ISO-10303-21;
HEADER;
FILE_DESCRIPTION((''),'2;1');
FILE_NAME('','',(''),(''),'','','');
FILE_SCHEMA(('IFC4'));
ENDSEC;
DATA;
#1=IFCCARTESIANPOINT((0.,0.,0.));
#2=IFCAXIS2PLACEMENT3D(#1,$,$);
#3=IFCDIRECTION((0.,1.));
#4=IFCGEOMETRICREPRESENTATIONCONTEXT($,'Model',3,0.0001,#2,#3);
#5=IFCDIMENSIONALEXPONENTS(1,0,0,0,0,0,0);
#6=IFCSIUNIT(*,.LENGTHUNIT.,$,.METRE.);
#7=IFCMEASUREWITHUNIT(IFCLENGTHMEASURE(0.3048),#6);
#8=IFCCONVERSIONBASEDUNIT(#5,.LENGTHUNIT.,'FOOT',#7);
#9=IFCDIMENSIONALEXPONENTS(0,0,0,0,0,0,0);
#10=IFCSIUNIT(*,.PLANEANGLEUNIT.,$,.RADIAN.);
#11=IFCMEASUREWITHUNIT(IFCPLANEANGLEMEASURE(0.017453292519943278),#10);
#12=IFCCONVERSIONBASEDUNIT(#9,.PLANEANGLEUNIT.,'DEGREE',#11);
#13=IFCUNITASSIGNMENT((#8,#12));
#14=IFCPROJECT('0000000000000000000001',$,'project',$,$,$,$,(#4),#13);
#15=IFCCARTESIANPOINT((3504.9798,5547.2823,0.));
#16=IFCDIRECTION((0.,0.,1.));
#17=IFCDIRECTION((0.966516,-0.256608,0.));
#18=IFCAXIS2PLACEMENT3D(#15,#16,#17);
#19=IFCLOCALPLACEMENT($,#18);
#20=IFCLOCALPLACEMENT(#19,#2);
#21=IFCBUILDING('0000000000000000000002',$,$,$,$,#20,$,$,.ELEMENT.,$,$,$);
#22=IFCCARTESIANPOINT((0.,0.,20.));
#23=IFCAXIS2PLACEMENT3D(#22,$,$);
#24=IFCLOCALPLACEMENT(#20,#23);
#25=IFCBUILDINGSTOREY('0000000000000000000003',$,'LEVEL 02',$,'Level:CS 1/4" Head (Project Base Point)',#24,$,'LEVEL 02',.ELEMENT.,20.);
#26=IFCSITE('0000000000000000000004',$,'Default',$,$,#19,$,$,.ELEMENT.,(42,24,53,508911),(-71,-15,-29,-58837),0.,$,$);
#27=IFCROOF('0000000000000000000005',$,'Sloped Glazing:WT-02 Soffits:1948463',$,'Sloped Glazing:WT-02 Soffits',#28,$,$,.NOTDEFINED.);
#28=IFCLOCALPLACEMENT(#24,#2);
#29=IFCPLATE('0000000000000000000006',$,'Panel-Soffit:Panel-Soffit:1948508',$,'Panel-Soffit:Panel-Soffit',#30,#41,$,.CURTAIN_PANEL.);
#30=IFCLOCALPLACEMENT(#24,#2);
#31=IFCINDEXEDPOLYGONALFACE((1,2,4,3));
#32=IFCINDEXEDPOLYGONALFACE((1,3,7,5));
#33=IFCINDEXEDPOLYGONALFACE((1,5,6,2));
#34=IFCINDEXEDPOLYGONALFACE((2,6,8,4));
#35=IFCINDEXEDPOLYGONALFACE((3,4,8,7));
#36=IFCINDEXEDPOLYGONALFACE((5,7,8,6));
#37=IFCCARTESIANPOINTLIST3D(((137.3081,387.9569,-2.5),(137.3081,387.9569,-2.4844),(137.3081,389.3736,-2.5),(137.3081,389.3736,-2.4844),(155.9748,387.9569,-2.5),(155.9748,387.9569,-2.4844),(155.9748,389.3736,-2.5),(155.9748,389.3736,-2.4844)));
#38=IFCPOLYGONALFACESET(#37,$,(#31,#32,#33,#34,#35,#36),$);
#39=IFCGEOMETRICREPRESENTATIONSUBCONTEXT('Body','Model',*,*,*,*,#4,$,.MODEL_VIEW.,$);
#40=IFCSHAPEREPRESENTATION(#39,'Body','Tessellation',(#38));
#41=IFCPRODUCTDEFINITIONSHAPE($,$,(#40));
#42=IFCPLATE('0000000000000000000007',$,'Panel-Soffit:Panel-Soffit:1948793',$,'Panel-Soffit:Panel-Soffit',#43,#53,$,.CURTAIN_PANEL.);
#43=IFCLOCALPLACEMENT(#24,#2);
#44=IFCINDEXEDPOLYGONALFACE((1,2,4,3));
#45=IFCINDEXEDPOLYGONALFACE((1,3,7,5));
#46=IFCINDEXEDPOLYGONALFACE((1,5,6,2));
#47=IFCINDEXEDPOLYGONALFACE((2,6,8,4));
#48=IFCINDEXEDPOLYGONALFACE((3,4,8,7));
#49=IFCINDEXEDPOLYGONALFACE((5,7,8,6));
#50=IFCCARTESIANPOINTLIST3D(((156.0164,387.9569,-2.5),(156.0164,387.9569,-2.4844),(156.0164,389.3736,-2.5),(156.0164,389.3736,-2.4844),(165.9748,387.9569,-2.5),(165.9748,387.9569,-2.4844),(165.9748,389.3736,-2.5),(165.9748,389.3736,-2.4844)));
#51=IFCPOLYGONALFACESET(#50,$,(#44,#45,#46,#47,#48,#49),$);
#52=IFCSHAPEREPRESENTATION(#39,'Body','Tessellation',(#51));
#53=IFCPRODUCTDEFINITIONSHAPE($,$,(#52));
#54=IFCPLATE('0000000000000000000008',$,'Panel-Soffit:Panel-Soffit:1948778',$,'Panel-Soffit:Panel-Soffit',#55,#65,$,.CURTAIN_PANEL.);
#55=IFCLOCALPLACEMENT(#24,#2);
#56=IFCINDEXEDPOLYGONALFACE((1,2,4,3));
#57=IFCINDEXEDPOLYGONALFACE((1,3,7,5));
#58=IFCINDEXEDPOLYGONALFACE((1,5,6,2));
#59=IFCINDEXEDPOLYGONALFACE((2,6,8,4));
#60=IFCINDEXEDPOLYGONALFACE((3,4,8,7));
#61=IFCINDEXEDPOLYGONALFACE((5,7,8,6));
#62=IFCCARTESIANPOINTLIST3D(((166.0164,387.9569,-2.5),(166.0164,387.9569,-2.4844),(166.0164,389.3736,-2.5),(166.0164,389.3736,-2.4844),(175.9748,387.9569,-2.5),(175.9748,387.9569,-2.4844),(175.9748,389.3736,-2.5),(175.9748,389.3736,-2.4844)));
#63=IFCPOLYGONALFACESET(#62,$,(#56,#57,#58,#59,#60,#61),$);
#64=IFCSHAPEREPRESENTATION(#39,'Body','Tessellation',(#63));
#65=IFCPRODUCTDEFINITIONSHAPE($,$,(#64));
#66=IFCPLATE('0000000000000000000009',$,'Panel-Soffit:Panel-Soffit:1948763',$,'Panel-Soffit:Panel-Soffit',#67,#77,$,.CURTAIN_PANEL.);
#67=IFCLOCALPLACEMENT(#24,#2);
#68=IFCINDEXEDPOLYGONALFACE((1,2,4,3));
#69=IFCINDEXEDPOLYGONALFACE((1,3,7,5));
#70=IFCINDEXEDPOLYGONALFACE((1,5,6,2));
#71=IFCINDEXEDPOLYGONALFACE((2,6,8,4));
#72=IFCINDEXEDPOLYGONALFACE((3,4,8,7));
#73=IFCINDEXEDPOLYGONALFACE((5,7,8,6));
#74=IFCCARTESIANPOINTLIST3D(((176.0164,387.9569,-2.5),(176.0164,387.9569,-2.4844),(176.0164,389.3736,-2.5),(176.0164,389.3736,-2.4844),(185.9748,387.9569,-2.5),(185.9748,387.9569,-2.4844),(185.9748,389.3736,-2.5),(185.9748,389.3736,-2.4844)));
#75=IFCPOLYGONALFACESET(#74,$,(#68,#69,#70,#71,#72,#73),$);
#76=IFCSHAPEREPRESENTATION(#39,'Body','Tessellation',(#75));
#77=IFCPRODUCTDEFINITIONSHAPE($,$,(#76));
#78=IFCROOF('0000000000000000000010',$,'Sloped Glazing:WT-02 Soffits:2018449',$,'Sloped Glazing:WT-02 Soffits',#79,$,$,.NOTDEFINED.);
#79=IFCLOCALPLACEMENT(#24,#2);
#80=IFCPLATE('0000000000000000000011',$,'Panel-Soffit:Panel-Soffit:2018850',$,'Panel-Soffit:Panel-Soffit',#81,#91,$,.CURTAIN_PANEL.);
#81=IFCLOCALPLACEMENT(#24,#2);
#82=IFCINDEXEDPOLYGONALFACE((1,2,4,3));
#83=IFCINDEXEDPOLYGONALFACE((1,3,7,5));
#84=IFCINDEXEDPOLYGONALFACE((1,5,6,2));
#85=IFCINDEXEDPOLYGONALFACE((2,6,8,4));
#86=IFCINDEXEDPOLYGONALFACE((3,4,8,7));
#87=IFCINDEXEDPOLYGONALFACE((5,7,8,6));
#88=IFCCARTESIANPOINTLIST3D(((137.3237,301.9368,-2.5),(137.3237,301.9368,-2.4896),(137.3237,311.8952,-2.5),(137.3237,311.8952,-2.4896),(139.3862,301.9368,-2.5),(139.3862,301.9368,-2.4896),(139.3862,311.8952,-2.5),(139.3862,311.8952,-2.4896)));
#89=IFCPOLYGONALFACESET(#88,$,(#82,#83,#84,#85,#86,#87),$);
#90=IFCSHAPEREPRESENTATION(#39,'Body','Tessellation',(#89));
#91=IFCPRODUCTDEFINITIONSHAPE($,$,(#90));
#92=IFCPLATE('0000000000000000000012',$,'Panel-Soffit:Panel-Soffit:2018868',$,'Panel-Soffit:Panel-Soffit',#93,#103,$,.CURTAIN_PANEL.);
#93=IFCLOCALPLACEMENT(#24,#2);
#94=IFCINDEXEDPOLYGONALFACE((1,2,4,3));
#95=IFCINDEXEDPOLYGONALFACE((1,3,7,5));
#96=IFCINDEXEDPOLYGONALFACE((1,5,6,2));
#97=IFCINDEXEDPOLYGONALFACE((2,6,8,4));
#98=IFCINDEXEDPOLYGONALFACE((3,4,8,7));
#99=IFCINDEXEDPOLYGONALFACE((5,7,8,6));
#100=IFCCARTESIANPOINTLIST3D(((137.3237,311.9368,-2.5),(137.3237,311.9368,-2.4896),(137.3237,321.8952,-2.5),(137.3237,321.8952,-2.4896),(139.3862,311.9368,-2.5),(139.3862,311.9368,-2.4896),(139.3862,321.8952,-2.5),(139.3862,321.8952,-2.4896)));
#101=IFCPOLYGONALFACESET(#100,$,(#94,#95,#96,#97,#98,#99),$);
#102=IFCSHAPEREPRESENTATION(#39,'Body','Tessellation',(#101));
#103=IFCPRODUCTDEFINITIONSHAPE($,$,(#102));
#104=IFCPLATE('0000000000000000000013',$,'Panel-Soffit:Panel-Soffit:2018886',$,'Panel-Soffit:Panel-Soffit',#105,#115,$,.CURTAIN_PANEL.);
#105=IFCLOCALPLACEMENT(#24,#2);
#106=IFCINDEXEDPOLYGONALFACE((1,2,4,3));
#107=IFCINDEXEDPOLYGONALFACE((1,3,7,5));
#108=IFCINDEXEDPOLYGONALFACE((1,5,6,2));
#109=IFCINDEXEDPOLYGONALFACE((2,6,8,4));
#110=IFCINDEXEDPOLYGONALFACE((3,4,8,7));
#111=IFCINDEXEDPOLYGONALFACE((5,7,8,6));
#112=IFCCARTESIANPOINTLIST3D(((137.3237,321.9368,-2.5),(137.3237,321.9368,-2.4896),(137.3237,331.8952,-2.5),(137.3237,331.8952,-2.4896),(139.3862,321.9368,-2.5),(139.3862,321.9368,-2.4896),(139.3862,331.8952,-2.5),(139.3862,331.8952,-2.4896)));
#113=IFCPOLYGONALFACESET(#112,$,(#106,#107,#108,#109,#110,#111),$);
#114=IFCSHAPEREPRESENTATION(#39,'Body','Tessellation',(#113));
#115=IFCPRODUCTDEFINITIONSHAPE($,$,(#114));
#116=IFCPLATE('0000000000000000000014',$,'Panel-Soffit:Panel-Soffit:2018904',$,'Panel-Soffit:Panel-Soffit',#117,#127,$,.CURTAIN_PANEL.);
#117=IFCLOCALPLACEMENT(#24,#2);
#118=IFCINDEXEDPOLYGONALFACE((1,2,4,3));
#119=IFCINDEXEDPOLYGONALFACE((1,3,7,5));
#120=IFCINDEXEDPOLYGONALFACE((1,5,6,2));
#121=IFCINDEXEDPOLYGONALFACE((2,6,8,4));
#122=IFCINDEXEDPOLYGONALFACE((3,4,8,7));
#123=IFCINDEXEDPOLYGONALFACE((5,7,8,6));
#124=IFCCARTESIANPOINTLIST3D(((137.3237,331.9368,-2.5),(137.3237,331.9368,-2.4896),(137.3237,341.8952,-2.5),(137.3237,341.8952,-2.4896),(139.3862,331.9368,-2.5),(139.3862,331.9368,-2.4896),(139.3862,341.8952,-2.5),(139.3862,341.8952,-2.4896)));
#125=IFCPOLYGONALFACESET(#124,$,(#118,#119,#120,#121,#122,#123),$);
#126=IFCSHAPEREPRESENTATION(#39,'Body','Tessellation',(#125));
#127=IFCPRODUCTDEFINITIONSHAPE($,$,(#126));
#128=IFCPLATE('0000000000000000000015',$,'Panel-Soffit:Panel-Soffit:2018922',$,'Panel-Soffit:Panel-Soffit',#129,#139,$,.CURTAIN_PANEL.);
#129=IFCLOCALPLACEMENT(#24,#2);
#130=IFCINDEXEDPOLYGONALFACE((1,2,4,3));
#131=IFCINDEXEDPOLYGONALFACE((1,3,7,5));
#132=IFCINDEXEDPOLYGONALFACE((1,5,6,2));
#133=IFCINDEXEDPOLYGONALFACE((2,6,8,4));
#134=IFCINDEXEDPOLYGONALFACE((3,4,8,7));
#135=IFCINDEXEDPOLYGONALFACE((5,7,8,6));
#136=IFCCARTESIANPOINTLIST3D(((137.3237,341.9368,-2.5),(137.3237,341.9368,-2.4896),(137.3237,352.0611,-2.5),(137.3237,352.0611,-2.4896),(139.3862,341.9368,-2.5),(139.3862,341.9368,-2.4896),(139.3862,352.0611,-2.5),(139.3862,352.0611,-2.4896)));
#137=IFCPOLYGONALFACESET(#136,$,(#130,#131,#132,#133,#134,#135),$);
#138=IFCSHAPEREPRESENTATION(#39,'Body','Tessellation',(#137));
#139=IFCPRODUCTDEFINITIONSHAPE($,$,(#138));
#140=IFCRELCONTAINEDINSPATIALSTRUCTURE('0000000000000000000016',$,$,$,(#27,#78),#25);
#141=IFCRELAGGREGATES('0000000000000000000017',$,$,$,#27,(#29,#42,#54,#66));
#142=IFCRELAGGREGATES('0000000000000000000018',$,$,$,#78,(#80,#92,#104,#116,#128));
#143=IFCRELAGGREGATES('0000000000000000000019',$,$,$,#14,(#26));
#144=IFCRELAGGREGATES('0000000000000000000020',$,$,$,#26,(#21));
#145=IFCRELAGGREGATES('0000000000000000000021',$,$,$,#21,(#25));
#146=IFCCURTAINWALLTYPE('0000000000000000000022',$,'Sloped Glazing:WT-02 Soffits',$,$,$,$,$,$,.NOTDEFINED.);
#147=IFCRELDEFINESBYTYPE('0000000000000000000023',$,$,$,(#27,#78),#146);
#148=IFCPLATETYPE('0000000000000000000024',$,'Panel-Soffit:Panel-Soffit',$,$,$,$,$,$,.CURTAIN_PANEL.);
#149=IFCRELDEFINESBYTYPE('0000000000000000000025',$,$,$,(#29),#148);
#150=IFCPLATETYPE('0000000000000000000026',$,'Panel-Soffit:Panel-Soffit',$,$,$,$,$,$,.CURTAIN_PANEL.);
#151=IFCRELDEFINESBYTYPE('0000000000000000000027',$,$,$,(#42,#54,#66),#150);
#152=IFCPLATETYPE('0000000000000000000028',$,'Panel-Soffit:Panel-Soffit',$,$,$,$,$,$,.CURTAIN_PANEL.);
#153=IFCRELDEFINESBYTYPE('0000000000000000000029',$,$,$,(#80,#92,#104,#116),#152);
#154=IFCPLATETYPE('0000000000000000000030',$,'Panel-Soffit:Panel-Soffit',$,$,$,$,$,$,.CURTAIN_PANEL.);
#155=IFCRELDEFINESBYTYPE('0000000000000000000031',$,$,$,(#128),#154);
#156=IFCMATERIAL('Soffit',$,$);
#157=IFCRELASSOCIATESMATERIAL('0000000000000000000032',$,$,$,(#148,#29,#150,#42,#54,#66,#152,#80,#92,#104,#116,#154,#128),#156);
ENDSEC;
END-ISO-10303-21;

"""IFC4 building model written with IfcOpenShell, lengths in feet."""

from ifc_helpers import new_model, entity, si_unit, converted_unit, direction, frame, origin, place, context, subcontext, project, spatial, indexed_curve, outline, extrude, source, transform, mapped, material, type_object, type_shapes, element, aggregate, save


model = new_model("IFC4")

# Units and contexts
model_context = context("Model", 3, precision=0.0001, world=origin(), true_north=direction((0.0, 1.0)))
body_context = subcontext(model_context, "Body", "Model", "MODEL_VIEW")
ifc_project = project(units=[converted_unit("LENGTHUNIT", "FOOT", entity("IfcLengthMeasure", 0.3048), si_unit("LENGTHUNIT", "METRE"), dimensions=[1, 0, 0, 0, 0, 0, 0]), converted_unit("PLANEANGLEUNIT", "DEGREE", entity("IfcPlaneAngleMeasure", 0.017453292519943278), si_unit("PLANEANGLEUNIT", "RADIAN"), dimensions=[0, 0, 0, 0, 0, 0, 0])], contexts=[model_context])

# Site, building, storey
site_placement = place(None, frame((3504.9798, 5547.2823, 0.0), z_axis=(0.0, 0.0, 1.0), x_axis=(0.966516, -0.256608, 0.0)))
site = spatial("IfcSite", under=ifc_project, at=site_placement, Name="Default", CompositionType="ELEMENT", RefLatitude=(42, 24, 53, 508911), RefLongitude=(-71, -15, -29, -58837), RefElevation=0.0)
building_placement = place(site_placement, origin())
building = spatial("IfcBuilding", under=site, at=building_placement, CompositionType="ELEMENT")
storey_placement = place(building_placement, frame((0.0, 0.0, 20.0)))
storey = spatial("IfcBuildingStorey", under=building, at=storey_placement, Name="LEVEL 02", ObjectType="Level:CS 1/4\" Head (Project Base Point)", LongName="LEVEL 02", CompositionType="ELEMENT", Elevation=20.0)

# Roofs, plates
curtain_wall_type_1 = type_object("IfcCurtainWallType", Name="Sloped Glazing:WT-02 Soffits", PredefinedType="NOTDEFINED")
ifc_material_1 = material(Name="Soffit")
roof_1_placement = place(storey_placement, frame((0.0, 0.0, -20.0)))
roof_1 = element("IfcRoof", 1, at=roof_1_placement, inside=storey, type_object=curtain_wall_type_1, Name="Sloped Glazing:WT-02 Soffits:1948463", ObjectType="Sloped Glazing:WT-02 Soffits", PredefinedType="NOTDEFINED")
plate_type_1 = type_object("IfcPlateType", Name="Panel-Soffit:Panel-Soffit", PredefinedType="CURTAIN_PANEL", material=ifc_material_1)
shared_shape_1 = source(origin(), body_context, "Body", "SweptSolid", [
    extrude(outline(indexed_curve([(-0.0078, -9.3333), (0.0078, -9.3333), (0.0078, 9.3333), (-0.0078, 9.3333), (-0.0078, -9.3333)], self_intersect=False)), frame((9.3333, 0.0078, 0.0), z_axis=(0.0, 0.0, 1.0), x_axis=(0.0, -1.0, 0.0)), (0.0, 0.0, 1.0), 1.4167),
])
type_shapes(plate_type_1, [shared_shape_1])
plate_1_placement = place(roof_1_placement, frame((137.3081, 387.9569, 17.5156), z_axis=(0.0, 1.0, 0.0), x_axis=(1.0, 0.0, 0.0)))
plate_1 = element("IfcPlate", 2, at=plate_1_placement, type_object=plate_type_1, material=ifc_material_1, Name="Panel-Soffit:Panel-Soffit:1948508", ObjectType="Panel-Soffit:Panel-Soffit", PredefinedType="CURTAIN_PANEL", context=body_context, shape_type="MappedRepresentation", body=[
    mapped(shared_shape_1, transform((0.0, 0.0, 0.0), scale=1.0)),
])
plate_type_2 = type_object("IfcPlateType", Name="Panel-Soffit:Panel-Soffit", PredefinedType="CURTAIN_PANEL", material=ifc_material_1)
shared_shape_2 = source(origin(), body_context, "Body", "SweptSolid", [
    extrude(outline(indexed_curve([(-0.0078, -4.9792), (0.0078, -4.9792), (0.0078, 4.9792), (-0.0078, 4.9792), (-0.0078, -4.9792)], self_intersect=False)), frame((4.9792, 0.0078, 0.0), z_axis=(0.0, 0.0, 1.0), x_axis=(0.0, -1.0, 0.0)), (0.0, 0.0, 1.0), 1.4167),
])
type_shapes(plate_type_2, [shared_shape_2])
plate_2_placement = place(roof_1_placement, frame((156.0164, 387.9569, 17.5156), z_axis=(0.0, 1.0, 0.0), x_axis=(1.0, 0.0, 0.0)))
plate_2 = element("IfcPlate", 3, at=plate_2_placement, type_object=plate_type_2, material=ifc_material_1, Name="Panel-Soffit:Panel-Soffit:1948793", ObjectType="Panel-Soffit:Panel-Soffit", PredefinedType="CURTAIN_PANEL", context=body_context, shape_type="MappedRepresentation", body=[
    mapped(shared_shape_2, transform((0.0, 0.0, 0.0), scale=1.0)),
])
plate_3_placement = place(roof_1_placement, frame((166.0164, 387.9569, 17.5156), z_axis=(0.0, 1.0, 0.0), x_axis=(1.0, 0.0, 0.0)))
plate_3 = element("IfcPlate", 4, at=plate_3_placement, type_object=plate_type_2, material=ifc_material_1, Name="Panel-Soffit:Panel-Soffit:1948778", ObjectType="Panel-Soffit:Panel-Soffit", PredefinedType="CURTAIN_PANEL", context=body_context, shape_type="MappedRepresentation", body=[
    mapped(shared_shape_2, transform((0.0, 0.0, 0.0), scale=1.0)),
])
plate_4_placement = place(roof_1_placement, frame((176.0164, 387.9569, 17.5156), z_axis=(0.0, 1.0, 0.0), x_axis=(1.0, 0.0, 0.0)))
plate_4 = element("IfcPlate", 5, at=plate_4_placement, type_object=plate_type_2, material=ifc_material_1, Name="Panel-Soffit:Panel-Soffit:1948763", ObjectType="Panel-Soffit:Panel-Soffit", PredefinedType="CURTAIN_PANEL", context=body_context, shape_type="MappedRepresentation", body=[
    mapped(shared_shape_2, transform((0.0, 0.0, 0.0), scale=1.0)),
])
aggregate(roof_1, [plate_1, plate_2, plate_3, plate_4])
roof_2_placement = place(storey_placement, frame((0.0, 0.0, -20.0)))
roof_2 = element("IfcRoof", 6, at=roof_2_placement, inside=storey, type_object=curtain_wall_type_1, Name="Sloped Glazing:WT-02 Soffits:2018449", ObjectType="Sloped Glazing:WT-02 Soffits", PredefinedType="NOTDEFINED")
plate_type_3 = type_object("IfcPlateType", Name="Panel-Soffit:Panel-Soffit", PredefinedType="CURTAIN_PANEL", material=ifc_material_1)
shared_shape_3 = source(origin(), body_context, "Body", "SweptSolid", [
    extrude(outline(indexed_curve([(-0.0052, -1.0313), (0.0052, -1.0313), (0.0052, 1.0313), (-0.0052, 1.0313), (-0.0052, -1.0313)], self_intersect=False)), frame((1.0313, 0.0052, 0.0), z_axis=(0.0, 0.0, 1.0), x_axis=(0.0, -1.0, 0.0)), (0.0, 0.0, 1.0), 9.9583),
])
type_shapes(plate_type_3, [shared_shape_3])
plate_5_placement = place(roof_2_placement, frame((137.3237, 301.9368, 17.5104), z_axis=(0.0, 1.0, 0.0), x_axis=(1.0, 0.0, 0.0)))
plate_5 = element("IfcPlate", 7, at=plate_5_placement, type_object=plate_type_3, material=ifc_material_1, Name="Panel-Soffit:Panel-Soffit:2018850", ObjectType="Panel-Soffit:Panel-Soffit", PredefinedType="CURTAIN_PANEL", context=body_context, shape_type="MappedRepresentation", body=[
    mapped(shared_shape_3, transform((0.0, 0.0, 0.0), scale=1.0)),
])
plate_6_placement = place(roof_2_placement, frame((137.3237, 311.9368, 17.5104), z_axis=(0.0, 1.0, 0.0), x_axis=(1.0, 0.0, 0.0)))
plate_6 = element("IfcPlate", 8, at=plate_6_placement, type_object=plate_type_3, material=ifc_material_1, Name="Panel-Soffit:Panel-Soffit:2018868", ObjectType="Panel-Soffit:Panel-Soffit", PredefinedType="CURTAIN_PANEL", context=body_context, shape_type="MappedRepresentation", body=[
    mapped(shared_shape_3, transform((0.0, 0.0, 0.0), scale=1.0)),
])
plate_7_placement = place(roof_2_placement, frame((137.3237, 321.9368, 17.5104), z_axis=(0.0, 1.0, 0.0), x_axis=(1.0, 0.0, 0.0)))
plate_7 = element("IfcPlate", 9, at=plate_7_placement, type_object=plate_type_3, material=ifc_material_1, Name="Panel-Soffit:Panel-Soffit:2018886", ObjectType="Panel-Soffit:Panel-Soffit", PredefinedType="CURTAIN_PANEL", context=body_context, shape_type="MappedRepresentation", body=[
    mapped(shared_shape_3, transform((0.0, 0.0, 0.0), scale=1.0)),
])
plate_8_placement = place(roof_2_placement, frame((137.3237, 331.9368, 17.5104), z_axis=(0.0, 1.0, 0.0), x_axis=(1.0, 0.0, 0.0)))
plate_8 = element("IfcPlate", 10, at=plate_8_placement, type_object=plate_type_3, material=ifc_material_1, Name="Panel-Soffit:Panel-Soffit:2018904", ObjectType="Panel-Soffit:Panel-Soffit", PredefinedType="CURTAIN_PANEL", context=body_context, shape_type="MappedRepresentation", body=[
    mapped(shared_shape_3, transform((0.0, 0.0, 0.0), scale=1.0)),
])
plate_type_4 = type_object("IfcPlateType", Name="Panel-Soffit:Panel-Soffit", PredefinedType="CURTAIN_PANEL", material=ifc_material_1)
shared_shape_4 = source(origin(), body_context, "Body", "SweptSolid", [
    extrude(outline(indexed_curve([(-0.0052, -1.0313), (0.0052, -1.0313), (0.0052, 1.0313), (-0.0052, 1.0313), (-0.0052, -1.0313)], self_intersect=False)), frame((1.0313, 0.0052, 0.0), z_axis=(0.0, 0.0, 1.0), x_axis=(0.0, -1.0, 0.0)), (0.0, 0.0, 1.0), 10.1242),
])
type_shapes(plate_type_4, [shared_shape_4])
plate_9_placement = place(roof_2_placement, frame((137.3237, 341.9368, 17.5104), z_axis=(0.0, 1.0, 0.0), x_axis=(1.0, 0.0, 0.0)))
plate_9 = element("IfcPlate", 11, at=plate_9_placement, type_object=plate_type_4, material=ifc_material_1, Name="Panel-Soffit:Panel-Soffit:2018922", ObjectType="Panel-Soffit:Panel-Soffit", PredefinedType="CURTAIN_PANEL", context=body_context, shape_type="MappedRepresentation", body=[
    mapped(shared_shape_4, transform((0.0, 0.0, 0.0), scale=1.0)),
])
aggregate(roof_2, [plate_5, plate_6, plate_7, plate_8, plate_9])

save(model, "model.ifc")
